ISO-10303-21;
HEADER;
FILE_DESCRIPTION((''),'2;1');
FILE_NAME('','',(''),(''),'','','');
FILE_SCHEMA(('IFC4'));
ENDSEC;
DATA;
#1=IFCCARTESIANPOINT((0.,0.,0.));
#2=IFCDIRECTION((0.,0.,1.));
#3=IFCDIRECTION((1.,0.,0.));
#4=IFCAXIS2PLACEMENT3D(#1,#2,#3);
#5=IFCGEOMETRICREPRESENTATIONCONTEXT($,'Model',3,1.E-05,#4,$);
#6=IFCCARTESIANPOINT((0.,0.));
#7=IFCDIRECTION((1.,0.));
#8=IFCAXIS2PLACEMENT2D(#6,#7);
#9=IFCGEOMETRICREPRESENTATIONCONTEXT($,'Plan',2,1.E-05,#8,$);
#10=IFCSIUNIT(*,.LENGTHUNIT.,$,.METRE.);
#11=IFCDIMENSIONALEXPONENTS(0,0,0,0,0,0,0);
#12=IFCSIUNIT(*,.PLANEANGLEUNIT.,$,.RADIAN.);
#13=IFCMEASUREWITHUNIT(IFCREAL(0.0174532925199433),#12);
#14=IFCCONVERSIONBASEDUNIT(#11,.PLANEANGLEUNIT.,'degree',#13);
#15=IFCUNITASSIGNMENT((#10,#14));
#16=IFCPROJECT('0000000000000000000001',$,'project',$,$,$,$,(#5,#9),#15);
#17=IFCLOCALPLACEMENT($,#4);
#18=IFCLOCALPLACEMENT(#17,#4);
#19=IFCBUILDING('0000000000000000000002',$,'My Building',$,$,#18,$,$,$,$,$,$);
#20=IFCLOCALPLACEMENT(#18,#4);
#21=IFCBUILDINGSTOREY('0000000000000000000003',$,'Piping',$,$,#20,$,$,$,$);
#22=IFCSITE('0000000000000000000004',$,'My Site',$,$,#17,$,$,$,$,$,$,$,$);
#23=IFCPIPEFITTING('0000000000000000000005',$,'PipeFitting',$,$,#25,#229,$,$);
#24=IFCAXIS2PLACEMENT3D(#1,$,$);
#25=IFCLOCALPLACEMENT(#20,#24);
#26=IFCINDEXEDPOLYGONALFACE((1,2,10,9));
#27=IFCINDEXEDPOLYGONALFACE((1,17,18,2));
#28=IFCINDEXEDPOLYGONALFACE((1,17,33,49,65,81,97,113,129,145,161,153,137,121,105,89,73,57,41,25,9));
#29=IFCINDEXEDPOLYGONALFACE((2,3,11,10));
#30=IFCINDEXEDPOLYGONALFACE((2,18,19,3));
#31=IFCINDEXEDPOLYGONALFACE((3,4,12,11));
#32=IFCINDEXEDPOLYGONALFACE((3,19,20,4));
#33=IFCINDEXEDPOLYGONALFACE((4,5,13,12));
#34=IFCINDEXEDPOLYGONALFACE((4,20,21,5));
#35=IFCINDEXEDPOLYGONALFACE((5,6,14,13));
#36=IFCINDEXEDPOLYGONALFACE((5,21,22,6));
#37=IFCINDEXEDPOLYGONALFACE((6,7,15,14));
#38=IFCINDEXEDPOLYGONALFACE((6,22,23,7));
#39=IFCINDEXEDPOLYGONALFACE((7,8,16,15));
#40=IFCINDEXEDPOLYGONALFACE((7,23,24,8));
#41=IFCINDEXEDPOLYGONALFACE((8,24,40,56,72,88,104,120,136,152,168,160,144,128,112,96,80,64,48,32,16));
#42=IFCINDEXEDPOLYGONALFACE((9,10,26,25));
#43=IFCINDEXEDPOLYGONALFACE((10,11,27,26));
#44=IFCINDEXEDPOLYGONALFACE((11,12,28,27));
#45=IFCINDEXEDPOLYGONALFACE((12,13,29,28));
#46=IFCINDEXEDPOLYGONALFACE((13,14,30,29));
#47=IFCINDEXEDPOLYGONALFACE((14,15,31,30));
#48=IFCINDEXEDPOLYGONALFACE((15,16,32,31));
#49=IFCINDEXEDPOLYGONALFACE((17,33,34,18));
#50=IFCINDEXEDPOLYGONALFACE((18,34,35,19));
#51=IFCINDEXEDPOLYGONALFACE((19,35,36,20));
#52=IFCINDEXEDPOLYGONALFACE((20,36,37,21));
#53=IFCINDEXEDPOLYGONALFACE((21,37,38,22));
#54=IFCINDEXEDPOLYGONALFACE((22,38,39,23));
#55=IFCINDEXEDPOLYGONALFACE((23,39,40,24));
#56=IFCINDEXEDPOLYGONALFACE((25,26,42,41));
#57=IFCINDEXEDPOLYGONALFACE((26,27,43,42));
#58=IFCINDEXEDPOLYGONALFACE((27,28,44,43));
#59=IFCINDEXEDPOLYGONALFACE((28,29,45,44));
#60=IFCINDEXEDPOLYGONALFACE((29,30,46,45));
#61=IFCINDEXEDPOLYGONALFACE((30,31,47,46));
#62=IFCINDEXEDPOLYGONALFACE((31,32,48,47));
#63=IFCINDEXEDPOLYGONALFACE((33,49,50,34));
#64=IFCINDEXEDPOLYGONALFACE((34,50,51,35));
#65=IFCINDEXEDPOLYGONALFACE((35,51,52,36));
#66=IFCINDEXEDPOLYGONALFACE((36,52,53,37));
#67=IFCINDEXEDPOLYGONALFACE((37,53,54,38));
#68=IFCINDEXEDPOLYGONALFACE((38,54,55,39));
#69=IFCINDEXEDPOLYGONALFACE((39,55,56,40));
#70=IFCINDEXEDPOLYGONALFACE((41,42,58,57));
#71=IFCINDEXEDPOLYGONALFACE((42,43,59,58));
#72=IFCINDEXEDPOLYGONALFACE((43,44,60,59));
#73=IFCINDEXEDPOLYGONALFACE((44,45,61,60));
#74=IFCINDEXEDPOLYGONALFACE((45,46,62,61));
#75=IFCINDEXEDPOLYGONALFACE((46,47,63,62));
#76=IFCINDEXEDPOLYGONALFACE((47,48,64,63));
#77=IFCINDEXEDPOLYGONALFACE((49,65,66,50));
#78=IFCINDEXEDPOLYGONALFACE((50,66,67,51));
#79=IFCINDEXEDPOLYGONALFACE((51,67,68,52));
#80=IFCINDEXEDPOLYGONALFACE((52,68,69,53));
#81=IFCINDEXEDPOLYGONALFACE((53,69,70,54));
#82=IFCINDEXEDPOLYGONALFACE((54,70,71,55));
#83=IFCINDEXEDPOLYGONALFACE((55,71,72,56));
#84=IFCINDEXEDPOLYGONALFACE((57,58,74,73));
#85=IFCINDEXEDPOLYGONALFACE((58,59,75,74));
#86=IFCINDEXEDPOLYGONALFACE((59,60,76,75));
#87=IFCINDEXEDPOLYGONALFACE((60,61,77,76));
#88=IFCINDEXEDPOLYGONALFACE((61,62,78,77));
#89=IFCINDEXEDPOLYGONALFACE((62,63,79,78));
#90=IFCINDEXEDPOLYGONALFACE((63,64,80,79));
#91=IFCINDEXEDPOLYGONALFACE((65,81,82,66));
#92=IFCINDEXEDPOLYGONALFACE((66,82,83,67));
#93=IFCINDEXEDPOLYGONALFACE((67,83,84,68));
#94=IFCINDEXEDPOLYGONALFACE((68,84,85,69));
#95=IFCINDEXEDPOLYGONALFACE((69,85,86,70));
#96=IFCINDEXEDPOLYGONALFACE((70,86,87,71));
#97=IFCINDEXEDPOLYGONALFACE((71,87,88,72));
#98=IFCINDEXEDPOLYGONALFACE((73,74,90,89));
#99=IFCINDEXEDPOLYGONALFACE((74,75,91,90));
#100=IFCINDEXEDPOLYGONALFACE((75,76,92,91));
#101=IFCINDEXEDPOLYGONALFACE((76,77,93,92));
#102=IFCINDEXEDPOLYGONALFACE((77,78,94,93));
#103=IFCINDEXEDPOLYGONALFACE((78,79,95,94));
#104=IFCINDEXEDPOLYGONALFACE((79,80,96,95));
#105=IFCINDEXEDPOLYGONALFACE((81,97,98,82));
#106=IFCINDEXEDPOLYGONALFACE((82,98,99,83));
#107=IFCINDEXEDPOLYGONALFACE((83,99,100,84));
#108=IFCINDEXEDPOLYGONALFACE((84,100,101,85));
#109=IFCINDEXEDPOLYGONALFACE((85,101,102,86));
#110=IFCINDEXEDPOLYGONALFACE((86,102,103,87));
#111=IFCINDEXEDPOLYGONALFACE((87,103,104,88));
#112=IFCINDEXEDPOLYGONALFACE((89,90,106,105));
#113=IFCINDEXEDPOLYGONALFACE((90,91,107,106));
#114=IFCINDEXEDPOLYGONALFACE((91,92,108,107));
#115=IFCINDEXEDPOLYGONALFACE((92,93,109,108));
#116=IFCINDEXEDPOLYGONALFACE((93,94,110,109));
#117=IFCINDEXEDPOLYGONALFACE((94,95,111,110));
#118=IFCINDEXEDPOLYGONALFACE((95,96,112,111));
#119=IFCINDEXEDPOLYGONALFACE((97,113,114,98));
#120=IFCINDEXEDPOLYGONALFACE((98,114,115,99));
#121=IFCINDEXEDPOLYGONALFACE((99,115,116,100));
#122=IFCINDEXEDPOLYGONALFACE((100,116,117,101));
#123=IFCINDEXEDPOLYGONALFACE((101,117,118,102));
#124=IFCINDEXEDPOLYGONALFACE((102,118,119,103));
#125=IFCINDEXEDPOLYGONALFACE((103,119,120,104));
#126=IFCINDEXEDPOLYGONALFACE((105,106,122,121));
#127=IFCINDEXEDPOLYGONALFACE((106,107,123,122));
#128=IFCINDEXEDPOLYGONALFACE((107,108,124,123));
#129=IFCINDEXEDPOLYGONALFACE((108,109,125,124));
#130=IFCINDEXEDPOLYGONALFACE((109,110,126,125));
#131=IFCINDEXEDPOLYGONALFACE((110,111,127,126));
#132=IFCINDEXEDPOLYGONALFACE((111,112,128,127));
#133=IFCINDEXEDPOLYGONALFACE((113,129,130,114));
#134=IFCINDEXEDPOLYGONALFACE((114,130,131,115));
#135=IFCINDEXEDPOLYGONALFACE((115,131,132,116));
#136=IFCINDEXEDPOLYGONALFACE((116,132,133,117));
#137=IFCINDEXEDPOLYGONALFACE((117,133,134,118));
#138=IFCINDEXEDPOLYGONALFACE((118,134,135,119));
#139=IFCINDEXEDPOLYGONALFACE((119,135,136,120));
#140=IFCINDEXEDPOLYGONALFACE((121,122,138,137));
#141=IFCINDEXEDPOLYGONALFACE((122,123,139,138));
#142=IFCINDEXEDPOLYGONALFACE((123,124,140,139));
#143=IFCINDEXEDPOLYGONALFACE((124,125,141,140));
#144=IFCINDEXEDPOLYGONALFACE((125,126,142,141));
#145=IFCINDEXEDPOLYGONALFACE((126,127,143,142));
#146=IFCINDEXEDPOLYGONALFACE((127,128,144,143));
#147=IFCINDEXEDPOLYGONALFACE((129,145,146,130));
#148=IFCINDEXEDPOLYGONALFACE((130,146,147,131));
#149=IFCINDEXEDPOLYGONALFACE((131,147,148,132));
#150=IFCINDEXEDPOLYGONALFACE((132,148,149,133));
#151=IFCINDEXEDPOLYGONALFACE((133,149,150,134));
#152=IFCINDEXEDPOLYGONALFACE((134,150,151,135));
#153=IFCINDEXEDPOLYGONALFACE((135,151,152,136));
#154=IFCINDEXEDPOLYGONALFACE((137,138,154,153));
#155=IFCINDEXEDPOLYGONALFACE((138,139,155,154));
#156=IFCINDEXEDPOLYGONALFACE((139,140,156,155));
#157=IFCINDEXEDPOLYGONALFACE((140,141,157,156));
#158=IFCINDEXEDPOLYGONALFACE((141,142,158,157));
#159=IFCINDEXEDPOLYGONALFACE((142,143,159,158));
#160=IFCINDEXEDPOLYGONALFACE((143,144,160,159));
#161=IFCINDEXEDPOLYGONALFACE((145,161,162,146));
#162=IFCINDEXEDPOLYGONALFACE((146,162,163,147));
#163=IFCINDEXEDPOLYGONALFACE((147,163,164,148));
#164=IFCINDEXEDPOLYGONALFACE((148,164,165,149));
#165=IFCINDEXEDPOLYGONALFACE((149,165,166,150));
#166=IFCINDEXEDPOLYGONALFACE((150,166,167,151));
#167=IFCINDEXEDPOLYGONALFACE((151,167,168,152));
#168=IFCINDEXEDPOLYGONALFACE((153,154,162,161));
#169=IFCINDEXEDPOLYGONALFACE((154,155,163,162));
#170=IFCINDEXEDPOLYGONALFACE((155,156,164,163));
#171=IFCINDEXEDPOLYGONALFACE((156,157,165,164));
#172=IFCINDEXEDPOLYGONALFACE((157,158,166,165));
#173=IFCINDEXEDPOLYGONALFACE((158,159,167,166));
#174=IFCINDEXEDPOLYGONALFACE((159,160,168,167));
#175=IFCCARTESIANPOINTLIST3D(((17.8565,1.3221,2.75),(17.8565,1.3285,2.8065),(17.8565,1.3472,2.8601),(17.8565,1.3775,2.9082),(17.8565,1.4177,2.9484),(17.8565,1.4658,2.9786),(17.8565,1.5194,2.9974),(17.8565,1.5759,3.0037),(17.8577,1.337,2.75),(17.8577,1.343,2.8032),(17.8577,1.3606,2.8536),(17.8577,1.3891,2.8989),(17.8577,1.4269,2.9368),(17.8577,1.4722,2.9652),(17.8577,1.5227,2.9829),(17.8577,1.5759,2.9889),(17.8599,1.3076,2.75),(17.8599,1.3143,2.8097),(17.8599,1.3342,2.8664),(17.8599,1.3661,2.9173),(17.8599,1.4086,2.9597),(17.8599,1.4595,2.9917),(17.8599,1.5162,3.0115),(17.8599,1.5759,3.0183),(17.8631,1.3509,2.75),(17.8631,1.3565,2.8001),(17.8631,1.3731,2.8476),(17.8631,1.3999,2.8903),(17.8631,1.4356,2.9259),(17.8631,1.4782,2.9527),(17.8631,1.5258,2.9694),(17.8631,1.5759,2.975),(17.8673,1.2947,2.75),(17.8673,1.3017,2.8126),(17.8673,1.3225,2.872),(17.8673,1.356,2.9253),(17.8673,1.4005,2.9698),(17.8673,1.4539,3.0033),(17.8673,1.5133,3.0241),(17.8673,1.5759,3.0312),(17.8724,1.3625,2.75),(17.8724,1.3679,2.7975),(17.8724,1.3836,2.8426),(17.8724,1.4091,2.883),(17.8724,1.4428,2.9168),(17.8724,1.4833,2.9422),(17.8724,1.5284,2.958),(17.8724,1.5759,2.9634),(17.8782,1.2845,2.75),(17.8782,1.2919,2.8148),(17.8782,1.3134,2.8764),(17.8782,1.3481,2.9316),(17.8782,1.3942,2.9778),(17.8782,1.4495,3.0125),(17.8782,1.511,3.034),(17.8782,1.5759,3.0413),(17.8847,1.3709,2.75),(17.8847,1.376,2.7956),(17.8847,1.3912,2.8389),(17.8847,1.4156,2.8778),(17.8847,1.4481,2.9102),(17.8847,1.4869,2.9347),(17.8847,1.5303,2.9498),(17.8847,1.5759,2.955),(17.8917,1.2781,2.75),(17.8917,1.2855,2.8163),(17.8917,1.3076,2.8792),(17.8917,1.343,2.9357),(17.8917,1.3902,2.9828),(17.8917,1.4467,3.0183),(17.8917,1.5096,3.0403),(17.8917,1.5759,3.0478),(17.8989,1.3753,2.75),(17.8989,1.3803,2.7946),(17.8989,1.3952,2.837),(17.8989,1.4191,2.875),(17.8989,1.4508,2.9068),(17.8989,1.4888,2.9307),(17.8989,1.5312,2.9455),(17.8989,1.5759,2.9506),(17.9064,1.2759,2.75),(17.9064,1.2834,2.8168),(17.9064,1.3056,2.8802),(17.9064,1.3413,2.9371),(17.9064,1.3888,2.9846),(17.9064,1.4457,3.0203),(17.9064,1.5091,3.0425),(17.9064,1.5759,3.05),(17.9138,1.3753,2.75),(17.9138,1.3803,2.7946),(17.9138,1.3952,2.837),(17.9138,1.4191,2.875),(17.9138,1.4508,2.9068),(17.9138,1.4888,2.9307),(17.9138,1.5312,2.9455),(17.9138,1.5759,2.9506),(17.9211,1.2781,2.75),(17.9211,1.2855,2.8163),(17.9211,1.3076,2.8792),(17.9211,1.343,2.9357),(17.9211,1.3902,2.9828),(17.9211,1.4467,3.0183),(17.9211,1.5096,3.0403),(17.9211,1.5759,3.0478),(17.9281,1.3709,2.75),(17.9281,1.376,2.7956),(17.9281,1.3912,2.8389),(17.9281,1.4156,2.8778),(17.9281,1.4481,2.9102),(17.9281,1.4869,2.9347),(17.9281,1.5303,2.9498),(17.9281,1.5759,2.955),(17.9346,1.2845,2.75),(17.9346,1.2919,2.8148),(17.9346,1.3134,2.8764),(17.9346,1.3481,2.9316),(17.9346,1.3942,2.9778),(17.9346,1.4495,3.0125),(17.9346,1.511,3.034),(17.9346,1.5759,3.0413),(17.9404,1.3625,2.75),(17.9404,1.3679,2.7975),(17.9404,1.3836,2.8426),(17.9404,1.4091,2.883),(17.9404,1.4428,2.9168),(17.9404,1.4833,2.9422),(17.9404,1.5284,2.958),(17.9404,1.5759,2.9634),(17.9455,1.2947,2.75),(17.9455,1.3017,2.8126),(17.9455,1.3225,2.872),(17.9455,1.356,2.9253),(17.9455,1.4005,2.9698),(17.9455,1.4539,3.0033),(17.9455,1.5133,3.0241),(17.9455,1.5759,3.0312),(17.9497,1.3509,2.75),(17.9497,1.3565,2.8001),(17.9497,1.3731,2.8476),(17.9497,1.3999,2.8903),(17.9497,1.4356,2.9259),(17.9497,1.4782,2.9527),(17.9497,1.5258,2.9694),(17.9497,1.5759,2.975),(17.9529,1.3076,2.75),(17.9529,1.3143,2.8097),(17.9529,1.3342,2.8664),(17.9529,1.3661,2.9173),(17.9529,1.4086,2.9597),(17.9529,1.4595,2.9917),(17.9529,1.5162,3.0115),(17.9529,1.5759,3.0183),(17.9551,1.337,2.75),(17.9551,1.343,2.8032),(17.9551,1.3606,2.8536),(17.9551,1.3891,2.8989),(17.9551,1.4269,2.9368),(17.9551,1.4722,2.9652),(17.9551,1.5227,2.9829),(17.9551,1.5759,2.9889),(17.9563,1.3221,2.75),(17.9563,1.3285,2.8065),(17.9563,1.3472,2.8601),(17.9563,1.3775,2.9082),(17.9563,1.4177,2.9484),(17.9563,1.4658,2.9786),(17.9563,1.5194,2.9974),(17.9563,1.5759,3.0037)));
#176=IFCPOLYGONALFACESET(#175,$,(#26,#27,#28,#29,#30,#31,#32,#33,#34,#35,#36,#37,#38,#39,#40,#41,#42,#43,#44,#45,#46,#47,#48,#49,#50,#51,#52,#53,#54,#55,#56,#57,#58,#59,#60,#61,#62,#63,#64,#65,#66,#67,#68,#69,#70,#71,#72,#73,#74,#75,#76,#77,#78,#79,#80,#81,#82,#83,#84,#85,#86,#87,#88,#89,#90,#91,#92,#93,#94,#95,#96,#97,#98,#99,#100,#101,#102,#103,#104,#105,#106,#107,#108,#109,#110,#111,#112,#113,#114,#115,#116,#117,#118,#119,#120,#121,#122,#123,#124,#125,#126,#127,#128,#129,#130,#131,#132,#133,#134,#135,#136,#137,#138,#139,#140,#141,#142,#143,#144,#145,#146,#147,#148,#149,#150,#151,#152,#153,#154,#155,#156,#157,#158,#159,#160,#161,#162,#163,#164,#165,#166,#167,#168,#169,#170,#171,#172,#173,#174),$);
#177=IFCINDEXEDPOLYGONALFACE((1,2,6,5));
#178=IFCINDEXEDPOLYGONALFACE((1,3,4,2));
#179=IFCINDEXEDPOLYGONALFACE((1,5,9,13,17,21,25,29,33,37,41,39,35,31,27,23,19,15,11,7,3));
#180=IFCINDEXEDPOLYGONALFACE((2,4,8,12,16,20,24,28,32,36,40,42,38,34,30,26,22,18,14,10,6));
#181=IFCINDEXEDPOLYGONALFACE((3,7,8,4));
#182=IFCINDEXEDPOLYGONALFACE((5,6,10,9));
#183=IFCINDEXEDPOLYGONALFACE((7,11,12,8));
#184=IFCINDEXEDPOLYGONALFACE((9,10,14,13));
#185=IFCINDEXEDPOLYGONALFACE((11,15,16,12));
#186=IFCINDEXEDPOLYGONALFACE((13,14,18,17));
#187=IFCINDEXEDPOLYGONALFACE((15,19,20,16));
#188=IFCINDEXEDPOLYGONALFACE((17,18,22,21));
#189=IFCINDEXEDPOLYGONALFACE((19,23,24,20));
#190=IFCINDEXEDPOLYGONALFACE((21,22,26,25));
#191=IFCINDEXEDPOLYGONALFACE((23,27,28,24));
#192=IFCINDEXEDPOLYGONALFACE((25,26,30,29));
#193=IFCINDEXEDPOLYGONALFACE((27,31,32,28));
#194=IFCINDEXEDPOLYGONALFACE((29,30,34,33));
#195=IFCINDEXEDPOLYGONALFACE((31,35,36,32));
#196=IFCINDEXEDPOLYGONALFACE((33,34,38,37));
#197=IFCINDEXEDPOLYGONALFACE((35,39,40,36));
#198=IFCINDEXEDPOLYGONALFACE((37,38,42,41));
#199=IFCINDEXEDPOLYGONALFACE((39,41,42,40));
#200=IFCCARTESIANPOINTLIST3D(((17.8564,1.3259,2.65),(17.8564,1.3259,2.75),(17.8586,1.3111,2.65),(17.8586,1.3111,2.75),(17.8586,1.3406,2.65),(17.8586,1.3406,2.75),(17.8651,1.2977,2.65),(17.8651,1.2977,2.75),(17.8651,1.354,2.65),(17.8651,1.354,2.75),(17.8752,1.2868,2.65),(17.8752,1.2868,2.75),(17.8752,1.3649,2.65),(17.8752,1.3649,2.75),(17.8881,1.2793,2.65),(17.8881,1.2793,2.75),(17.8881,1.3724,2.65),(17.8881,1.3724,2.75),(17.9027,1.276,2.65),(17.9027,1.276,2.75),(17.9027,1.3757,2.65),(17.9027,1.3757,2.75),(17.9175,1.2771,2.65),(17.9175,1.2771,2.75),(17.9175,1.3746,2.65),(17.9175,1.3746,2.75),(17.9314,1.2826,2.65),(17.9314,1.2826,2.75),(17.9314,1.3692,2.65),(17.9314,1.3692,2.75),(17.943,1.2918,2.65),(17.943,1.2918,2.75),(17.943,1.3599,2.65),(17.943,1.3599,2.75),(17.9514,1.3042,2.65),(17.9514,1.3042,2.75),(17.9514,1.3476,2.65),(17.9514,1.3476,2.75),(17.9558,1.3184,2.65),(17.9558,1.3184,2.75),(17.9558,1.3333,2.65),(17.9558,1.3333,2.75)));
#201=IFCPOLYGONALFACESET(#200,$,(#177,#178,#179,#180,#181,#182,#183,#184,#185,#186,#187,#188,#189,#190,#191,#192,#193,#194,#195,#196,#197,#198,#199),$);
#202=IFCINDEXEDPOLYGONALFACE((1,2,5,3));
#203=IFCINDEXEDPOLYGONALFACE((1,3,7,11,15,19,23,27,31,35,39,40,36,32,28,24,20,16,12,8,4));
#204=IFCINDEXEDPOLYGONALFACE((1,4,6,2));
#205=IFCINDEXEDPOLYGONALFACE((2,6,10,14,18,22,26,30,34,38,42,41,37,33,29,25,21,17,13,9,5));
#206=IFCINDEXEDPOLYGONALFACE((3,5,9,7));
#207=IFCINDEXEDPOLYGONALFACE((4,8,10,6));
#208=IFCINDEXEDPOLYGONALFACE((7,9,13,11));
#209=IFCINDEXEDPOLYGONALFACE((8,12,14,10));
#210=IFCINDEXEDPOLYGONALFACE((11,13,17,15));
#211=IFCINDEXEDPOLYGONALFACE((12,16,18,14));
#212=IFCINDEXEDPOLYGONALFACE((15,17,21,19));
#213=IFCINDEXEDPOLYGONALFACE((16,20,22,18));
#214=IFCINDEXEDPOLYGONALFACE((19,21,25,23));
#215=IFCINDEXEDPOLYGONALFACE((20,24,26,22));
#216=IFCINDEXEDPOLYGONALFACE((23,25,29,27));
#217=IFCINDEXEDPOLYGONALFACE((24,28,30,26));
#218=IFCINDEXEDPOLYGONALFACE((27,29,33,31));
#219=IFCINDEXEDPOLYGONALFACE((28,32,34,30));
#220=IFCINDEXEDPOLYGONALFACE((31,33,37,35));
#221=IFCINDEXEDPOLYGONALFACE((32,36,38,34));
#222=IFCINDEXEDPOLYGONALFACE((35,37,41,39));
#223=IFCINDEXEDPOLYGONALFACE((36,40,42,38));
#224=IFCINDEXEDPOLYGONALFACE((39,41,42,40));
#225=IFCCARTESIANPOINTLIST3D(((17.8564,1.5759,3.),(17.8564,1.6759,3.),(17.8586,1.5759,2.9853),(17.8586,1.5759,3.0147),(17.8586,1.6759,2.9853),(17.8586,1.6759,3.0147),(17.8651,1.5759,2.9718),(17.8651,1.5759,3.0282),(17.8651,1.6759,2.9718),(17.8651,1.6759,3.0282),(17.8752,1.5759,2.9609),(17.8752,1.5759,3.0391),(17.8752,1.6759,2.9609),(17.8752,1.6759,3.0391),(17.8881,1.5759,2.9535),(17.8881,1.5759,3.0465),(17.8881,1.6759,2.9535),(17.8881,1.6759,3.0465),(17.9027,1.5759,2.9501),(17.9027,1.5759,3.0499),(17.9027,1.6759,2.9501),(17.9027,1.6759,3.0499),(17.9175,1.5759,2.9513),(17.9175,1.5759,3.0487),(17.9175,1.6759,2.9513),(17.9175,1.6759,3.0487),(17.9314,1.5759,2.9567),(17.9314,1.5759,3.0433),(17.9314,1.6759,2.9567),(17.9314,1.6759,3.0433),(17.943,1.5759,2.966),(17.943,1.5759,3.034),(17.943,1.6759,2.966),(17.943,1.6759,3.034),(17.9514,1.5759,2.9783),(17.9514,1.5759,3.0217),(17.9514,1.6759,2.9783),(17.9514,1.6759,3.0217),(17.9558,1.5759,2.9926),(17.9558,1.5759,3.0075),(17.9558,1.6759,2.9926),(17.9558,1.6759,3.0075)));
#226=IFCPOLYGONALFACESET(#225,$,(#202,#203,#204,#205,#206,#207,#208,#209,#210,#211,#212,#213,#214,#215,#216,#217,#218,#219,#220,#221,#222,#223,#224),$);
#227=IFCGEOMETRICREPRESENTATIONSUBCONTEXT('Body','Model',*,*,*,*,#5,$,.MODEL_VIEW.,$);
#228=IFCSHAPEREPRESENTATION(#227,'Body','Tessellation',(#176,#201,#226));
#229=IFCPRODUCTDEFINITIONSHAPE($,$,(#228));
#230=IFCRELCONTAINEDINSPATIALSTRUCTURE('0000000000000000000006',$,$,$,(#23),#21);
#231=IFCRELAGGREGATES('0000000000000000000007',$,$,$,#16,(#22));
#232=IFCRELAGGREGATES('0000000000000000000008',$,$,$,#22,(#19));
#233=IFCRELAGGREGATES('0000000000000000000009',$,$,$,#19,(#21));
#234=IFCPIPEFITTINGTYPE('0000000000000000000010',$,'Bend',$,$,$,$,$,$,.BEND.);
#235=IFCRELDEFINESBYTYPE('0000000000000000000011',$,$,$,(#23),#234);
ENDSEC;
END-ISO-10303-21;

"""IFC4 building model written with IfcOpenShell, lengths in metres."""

from ifc_helpers import new_model, entity, si_unit, converted_unit, frame, origin_with_axes, origin_2d_with_axis, place, context, subcontext, project, spatial, circle, extrude, source, transform, mapped, type_object, type_shapes, element, save


model = new_model("IFC4")

# Units and contexts
model_context = context("Model", 3, precision=1e-05, world=origin_with_axes())
plan_context = context("Plan", 2, precision=1e-05, world=origin_2d_with_axis())
body_context = subcontext(model_context, "Body", "Model", "MODEL_VIEW")
ifc_project = project(units=[si_unit("LENGTHUNIT", "METRE"), converted_unit("PLANEANGLEUNIT", "degree", entity("IfcReal", 0.0174532925199433), si_unit("PLANEANGLEUNIT", "RADIAN"), dimensions=[0, 0, 0, 0, 0, 0, 0])], contexts=[model_context, plan_context])

# Site, building, storey
site_placement = place(None, origin_with_axes())
site = spatial("IfcSite", under=ifc_project, at=site_placement, Name="My Site")
building_placement = place(site_placement, origin_with_axes())
building = spatial("IfcBuilding", under=site, at=building_placement, Name="My Building")
storey_placement = place(building_placement, origin_with_axes())
storey = spatial("IfcBuildingStorey", under=building, at=storey_placement, Name="Piping")

# Pipe fitting
pipe_fitting_type = type_object("IfcPipeFittingType", Name="Bend", PredefinedType="BEND")
shared_shape = source(origin_with_axes(), body_context, "Body", "SolidModel", [
    entity("IfcSweptDiskSolid", entity("IfcIndexedPolyCurve", entity("IfcCartesianPointList3D", [[0.0, 0.0, -0.1], [0.0, 0.0732, -0.2768], [0.0, 0.25, -0.35]]), [entity("IfcArcIndex", [1, 2, 3])]), 0.05),
    extrude(circle(Radius=0.05), origin_with_axes(), (0.0, 0.0, -1.0), 0.1),
    extrude(circle(Radius=0.05), frame((0.0, 0.25, -0.35), z_axis=(0.0, 1.0, 0.0), x_axis=(1.0, 0.0, 0.0)), (0.0, 0.0, 1.0), 0.1),
])
type_shapes(pipe_fitting_type, [shared_shape])
for number, where, z_axis, x_axis, name in (
    (1, (17.9064, 1.3259, 2.65), (0.0, 0.0, -1.0), (-1.0, 0.0, 0.0), "PipeFitting"),
):
    element("IfcPipeFitting", number, at=place(storey_placement, frame(where, z_axis=z_axis, x_axis=x_axis)), inside=storey, type_object=pipe_fitting_type, Name=name, context=body_context, shape_type="MappedRepresentation", body=[
        mapped(shared_shape, transform((0.0, 0.0, 0.0), x_axis=(1.0, 0.0, 0.0), y_axis=(0.0, 1.0, 0.0), z_axis=(0.0, 0.0, 1.0), scale=1.0)),
    ])

save(model, "model.ifc")
